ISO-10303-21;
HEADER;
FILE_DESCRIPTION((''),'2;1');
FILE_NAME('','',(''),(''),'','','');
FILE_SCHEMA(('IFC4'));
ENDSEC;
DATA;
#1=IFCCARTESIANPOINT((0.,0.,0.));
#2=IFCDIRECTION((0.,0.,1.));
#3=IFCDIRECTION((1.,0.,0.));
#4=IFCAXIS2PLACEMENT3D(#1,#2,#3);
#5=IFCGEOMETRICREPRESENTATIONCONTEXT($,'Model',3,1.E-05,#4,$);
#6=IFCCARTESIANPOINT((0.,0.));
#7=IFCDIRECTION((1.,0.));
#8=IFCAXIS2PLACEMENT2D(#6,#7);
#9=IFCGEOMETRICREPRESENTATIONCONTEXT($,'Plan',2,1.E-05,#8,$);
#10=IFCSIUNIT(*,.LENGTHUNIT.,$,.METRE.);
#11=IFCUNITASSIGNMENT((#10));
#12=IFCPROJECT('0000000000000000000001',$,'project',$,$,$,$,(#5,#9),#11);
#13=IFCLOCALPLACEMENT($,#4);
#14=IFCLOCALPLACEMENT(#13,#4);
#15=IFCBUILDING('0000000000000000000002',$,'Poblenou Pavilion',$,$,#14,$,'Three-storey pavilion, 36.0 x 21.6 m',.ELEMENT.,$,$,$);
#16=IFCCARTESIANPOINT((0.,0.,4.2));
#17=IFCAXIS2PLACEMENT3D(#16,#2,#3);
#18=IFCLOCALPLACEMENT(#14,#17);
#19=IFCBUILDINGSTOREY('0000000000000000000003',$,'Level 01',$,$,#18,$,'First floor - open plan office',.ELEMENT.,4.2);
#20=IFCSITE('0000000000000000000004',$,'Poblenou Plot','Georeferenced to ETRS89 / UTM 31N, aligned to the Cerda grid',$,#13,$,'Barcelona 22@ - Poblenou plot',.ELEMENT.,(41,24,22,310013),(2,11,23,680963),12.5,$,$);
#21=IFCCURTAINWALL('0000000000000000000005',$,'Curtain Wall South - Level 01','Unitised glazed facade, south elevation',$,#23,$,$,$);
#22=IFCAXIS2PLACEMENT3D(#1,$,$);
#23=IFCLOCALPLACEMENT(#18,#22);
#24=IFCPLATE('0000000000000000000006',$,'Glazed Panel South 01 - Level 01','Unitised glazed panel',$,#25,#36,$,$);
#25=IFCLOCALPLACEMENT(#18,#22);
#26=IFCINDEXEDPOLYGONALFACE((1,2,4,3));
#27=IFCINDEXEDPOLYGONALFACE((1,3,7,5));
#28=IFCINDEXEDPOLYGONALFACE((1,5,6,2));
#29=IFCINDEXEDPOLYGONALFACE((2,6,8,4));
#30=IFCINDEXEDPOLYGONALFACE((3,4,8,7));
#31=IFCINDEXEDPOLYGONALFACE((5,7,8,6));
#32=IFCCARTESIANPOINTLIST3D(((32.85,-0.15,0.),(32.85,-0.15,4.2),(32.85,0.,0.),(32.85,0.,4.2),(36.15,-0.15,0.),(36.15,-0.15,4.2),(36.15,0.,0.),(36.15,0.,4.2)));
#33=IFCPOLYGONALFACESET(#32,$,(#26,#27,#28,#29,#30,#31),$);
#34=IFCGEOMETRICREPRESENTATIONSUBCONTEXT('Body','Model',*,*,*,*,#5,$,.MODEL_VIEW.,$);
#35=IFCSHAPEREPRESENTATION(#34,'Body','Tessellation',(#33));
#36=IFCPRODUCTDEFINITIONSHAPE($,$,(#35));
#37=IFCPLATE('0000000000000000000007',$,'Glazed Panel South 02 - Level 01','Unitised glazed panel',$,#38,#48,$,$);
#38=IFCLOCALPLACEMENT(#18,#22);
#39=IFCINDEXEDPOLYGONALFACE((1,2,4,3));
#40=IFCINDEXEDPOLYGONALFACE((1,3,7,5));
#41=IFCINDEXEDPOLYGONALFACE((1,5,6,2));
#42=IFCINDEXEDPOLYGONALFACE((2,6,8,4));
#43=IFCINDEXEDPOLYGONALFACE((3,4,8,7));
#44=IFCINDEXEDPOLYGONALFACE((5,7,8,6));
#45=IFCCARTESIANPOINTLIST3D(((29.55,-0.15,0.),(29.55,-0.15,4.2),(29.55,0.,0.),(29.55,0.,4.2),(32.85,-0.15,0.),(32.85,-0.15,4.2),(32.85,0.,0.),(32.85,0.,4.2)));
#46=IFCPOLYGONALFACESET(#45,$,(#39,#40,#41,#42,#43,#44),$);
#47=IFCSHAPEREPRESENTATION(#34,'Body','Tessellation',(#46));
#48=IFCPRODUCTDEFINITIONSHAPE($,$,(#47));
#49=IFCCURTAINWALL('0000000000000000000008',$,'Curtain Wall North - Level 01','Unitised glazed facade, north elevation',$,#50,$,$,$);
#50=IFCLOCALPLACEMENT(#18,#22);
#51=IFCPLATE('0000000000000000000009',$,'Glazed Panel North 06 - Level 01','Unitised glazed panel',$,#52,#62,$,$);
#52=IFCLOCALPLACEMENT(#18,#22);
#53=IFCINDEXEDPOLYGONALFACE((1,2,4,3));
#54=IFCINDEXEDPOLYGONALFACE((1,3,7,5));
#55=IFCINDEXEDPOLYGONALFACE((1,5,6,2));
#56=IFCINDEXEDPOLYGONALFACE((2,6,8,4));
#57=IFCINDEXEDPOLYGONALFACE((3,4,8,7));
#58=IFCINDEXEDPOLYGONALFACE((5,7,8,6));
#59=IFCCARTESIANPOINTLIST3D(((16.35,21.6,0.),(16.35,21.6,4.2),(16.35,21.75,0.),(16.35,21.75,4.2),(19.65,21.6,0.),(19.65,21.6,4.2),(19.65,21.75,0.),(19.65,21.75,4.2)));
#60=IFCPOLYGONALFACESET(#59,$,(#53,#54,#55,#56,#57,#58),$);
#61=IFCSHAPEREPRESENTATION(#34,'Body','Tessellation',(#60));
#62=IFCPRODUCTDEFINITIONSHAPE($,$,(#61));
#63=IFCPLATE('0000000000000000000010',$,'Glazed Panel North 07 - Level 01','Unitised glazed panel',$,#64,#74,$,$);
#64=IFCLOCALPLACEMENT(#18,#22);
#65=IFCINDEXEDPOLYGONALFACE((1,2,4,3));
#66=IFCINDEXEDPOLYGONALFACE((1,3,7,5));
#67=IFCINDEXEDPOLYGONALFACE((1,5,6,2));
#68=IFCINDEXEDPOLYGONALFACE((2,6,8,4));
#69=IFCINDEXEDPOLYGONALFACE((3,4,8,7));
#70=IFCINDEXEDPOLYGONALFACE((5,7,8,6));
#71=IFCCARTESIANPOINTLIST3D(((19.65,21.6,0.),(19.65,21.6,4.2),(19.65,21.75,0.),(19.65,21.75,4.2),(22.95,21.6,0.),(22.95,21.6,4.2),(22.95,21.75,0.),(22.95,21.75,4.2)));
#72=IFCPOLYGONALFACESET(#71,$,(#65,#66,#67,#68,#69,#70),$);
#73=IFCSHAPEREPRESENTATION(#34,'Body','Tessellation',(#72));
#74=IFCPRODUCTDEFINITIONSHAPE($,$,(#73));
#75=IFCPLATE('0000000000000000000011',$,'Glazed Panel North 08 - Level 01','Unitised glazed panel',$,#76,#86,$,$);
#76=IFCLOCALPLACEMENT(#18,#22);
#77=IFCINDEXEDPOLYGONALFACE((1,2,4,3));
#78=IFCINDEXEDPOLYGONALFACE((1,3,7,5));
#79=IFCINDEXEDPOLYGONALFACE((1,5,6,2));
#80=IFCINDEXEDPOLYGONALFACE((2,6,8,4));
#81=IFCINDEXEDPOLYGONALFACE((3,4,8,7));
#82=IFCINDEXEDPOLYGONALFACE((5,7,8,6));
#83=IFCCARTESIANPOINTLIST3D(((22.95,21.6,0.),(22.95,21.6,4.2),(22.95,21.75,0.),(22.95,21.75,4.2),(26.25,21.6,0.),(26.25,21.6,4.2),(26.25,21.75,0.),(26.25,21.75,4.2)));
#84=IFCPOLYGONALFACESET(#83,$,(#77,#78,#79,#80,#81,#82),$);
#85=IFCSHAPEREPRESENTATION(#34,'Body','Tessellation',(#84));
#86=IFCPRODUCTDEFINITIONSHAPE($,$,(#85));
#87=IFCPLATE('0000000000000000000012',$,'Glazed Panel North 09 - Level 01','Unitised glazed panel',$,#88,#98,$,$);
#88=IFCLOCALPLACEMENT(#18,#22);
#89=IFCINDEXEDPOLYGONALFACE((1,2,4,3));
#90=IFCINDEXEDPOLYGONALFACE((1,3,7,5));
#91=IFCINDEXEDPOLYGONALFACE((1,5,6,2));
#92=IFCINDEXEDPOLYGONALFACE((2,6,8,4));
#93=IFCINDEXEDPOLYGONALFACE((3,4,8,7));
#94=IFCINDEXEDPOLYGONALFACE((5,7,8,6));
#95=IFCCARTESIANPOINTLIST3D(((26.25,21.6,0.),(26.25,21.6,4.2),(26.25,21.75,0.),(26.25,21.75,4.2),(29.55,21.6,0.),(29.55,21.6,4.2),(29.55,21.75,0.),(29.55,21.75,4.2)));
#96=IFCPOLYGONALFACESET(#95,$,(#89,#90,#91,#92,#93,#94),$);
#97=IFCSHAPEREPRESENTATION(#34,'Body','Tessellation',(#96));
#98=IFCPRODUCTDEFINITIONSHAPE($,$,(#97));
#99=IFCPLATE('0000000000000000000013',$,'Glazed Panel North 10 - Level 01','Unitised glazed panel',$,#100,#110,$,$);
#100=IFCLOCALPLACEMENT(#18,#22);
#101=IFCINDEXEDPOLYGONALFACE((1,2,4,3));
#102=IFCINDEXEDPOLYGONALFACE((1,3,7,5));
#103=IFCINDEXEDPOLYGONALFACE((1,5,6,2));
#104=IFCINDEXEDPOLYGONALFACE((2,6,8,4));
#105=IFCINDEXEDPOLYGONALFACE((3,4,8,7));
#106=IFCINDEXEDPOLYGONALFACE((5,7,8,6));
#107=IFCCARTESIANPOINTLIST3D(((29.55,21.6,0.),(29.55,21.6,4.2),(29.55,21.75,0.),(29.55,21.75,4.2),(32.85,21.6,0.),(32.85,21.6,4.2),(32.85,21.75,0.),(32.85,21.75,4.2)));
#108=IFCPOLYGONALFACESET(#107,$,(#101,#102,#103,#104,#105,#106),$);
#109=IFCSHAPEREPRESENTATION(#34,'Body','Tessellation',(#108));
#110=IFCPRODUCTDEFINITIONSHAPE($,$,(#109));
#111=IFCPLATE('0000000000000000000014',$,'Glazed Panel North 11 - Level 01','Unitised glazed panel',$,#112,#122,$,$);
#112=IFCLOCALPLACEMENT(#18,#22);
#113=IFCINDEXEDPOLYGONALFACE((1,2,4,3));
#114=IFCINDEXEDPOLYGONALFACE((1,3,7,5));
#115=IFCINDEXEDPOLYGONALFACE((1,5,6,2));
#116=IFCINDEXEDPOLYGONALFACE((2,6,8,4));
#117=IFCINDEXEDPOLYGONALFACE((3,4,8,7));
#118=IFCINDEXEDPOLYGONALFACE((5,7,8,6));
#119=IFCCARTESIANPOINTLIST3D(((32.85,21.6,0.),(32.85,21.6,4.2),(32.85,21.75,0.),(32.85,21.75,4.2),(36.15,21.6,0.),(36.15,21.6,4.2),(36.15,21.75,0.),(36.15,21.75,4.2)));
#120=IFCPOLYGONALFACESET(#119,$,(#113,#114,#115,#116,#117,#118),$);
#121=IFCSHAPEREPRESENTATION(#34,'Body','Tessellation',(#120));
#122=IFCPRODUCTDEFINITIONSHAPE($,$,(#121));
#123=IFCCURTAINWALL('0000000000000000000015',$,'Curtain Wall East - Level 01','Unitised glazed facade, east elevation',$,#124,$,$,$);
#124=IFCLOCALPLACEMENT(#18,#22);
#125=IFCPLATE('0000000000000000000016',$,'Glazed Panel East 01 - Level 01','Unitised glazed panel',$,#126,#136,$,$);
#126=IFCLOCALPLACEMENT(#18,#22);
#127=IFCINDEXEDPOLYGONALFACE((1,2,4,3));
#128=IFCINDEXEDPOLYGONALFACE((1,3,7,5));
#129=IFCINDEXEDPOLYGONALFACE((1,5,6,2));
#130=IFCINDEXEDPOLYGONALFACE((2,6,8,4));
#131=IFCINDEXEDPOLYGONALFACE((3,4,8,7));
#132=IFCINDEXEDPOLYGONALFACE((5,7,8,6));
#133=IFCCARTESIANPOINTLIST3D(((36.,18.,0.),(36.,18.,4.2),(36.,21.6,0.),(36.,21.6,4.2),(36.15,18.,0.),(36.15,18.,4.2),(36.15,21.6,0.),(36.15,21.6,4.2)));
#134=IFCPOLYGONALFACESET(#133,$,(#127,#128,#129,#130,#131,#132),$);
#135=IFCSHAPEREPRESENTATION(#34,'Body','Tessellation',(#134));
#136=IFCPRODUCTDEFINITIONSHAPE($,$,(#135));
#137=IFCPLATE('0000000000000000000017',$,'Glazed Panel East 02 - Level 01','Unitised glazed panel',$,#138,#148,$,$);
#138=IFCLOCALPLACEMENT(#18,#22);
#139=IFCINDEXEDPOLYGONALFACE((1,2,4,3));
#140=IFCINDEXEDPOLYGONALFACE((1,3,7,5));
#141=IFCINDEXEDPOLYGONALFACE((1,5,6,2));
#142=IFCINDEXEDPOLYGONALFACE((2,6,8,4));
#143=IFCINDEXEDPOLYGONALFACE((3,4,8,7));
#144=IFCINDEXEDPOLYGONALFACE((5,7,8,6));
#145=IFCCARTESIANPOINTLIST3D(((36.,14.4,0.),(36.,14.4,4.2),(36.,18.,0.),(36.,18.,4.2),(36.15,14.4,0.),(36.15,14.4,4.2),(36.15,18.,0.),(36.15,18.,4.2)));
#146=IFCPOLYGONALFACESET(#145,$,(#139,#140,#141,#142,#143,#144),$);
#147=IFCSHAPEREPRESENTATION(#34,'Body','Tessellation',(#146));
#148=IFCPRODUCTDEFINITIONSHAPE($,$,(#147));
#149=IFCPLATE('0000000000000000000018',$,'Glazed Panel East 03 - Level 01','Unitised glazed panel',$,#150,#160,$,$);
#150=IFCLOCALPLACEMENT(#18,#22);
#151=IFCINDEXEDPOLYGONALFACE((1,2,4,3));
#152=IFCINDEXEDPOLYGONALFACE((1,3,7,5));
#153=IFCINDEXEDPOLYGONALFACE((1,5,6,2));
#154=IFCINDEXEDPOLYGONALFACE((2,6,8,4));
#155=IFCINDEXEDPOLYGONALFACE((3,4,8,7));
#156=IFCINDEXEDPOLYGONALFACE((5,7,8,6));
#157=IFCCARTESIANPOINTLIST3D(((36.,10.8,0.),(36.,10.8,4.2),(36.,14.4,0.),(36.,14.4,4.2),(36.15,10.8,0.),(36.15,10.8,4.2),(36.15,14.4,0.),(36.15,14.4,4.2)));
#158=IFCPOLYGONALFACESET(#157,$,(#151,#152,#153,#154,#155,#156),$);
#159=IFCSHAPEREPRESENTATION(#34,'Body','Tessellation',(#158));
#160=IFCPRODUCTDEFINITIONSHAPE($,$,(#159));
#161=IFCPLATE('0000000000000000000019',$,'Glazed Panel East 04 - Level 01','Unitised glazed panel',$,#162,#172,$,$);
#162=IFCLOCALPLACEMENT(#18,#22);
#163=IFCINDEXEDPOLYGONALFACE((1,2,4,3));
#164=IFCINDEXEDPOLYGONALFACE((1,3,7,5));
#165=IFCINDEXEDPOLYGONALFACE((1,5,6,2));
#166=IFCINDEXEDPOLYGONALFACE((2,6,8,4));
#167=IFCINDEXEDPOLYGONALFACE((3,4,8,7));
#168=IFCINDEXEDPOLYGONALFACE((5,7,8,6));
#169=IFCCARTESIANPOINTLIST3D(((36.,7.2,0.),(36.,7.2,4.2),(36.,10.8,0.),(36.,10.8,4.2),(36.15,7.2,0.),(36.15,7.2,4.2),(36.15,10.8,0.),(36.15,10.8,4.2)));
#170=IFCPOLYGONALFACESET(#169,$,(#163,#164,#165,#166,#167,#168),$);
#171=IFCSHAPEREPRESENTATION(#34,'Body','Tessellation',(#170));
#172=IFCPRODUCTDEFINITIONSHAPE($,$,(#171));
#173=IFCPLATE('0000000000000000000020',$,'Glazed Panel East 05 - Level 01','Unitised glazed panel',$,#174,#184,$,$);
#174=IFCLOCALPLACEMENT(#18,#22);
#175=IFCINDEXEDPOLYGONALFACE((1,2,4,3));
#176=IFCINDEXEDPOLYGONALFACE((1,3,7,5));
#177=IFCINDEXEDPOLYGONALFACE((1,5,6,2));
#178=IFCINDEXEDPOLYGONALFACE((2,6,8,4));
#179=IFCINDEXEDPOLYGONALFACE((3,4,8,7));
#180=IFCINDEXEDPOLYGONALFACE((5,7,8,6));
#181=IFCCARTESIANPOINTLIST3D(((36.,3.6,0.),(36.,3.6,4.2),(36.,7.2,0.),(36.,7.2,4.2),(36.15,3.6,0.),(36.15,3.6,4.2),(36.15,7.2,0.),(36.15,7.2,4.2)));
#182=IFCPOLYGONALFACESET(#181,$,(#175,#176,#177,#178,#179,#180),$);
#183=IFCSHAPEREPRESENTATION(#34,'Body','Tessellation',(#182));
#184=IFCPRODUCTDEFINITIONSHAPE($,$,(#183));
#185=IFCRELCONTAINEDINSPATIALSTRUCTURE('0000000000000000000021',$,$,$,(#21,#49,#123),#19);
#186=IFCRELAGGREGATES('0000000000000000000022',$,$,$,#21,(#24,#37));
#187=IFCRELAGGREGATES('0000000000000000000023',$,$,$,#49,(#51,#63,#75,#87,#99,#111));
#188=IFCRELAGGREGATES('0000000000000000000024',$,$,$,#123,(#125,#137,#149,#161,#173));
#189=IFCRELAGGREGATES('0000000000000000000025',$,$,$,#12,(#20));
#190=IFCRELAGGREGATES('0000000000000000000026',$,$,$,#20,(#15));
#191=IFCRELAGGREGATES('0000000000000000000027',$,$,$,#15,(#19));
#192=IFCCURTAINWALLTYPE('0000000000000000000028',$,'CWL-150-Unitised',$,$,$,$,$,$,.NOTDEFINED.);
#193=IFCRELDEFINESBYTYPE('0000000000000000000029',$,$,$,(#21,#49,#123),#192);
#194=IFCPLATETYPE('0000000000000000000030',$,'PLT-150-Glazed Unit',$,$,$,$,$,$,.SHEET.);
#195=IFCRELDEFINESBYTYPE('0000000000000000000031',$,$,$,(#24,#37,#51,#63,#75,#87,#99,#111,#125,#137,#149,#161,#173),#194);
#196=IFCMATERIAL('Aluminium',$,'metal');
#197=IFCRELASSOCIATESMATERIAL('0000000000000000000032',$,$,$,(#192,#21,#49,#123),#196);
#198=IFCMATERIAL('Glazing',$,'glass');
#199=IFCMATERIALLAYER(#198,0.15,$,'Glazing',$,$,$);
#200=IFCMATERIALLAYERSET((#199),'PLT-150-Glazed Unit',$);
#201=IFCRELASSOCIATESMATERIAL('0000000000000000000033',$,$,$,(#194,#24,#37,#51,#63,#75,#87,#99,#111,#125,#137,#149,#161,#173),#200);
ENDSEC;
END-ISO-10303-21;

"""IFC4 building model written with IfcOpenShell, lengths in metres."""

from ifc_helpers import new_model, si_unit, frame, origin_with_axes, origin_2d_with_axis, place, context, subcontext, project, spatial, line, indexed_curve, outline, extrude, material, layer, layer_set, layer_usage, type_object, element, aggregate, save


model = new_model("IFC4")

# Units and contexts
model_context = context("Model", 3, precision=1e-05, world=origin_with_axes())
plan_context = context("Plan", 2, precision=1e-05, world=origin_2d_with_axis())
body_context = subcontext(model_context, "Body", "Model", "MODEL_VIEW")
ifc_project = project(units=[si_unit("LENGTHUNIT", "METRE")], contexts=[model_context, plan_context])

# Site, building, storey
site_placement = place(None, origin_with_axes())
site = spatial("IfcSite", under=ifc_project, at=site_placement, Name="Poblenou Plot", Description="Georeferenced to ETRS89 / UTM 31N, aligned to the Cerda grid", LongName="Barcelona 22@ - Poblenou plot", CompositionType="ELEMENT", RefLatitude=(41, 24, 22, 310013), RefLongitude=(2, 11, 23, 680963), RefElevation=12.5)
building_placement = place(site_placement, origin_with_axes())
building = spatial("IfcBuilding", under=site, at=building_placement, Name="Poblenou Pavilion", LongName="Three-storey pavilion, 36.0 x 21.6 m", CompositionType="ELEMENT")
storey_placement = place(building_placement, frame((0.0, 0.0, 4.2), z_axis=(0.0, 0.0, 1.0), x_axis=(1.0, 0.0, 0.0)))
storey = spatial("IfcBuildingStorey", under=building, at=storey_placement, Name="Level 01", LongName="First floor - open plan office", CompositionType="ELEMENT", Elevation=4.2)

# Curtain walls, plates
ifc_material_1 = material(Name="Aluminium", Category="metal")
curtain_wall_type = type_object("IfcCurtainWallType", Name="CWL-150-Unitised", PredefinedType="NOTDEFINED", material=ifc_material_1)
curtain_wall_1_placement = place(storey_placement, frame((36.15, 0.0, 0.0), z_axis=(0.0, 0.0, 1.0), x_axis=(-1.0, 0.0, 0.0)))
curtain_wall_1 = element("IfcCurtainWall", 1, at=curtain_wall_1_placement, inside=storey, type_object=curtain_wall_type, material=ifc_material_1, Name="Curtain Wall South - Level 01", Description="Unitised glazed facade, south elevation")
ifc_material_2 = material(Name="Glazing", Category="glass")
ifc_layer_1 = layer(ifc_material_2, 0.15, Name="Glazing")
ifc_layer_set_1 = layer_set([ifc_layer_1], Name="PLT-150-Glazed Unit")
ifc_layer_usage_1 = layer_usage(ifc_layer_set_1, "AXIS2", "POSITIVE", 0.0)
plate_type = type_object("IfcPlateType", Name="PLT-150-Glazed Unit", PredefinedType="SHEET", material=ifc_layer_set_1)
plate_1_placement = place(curtain_wall_1_placement, origin_with_axes())
plate_1 = element("IfcPlate", 2, at=plate_1_placement, type_object=plate_type, material=ifc_layer_usage_1, Name="Glazed Panel South 01 - Level 01", Description="Unitised glazed panel", context=body_context, shape_type="SweptSolid", body=[
    extrude(outline(indexed_curve([(0.0, 0.0), (3.3, 0.0), (3.3, 0.15), (0.0, 0.15)], segments=[line(1, 2, 3, 4, 1)])), origin_with_axes(), (0.0, 0.0, 1.0), 4.2),
])
ifc_layer_usage_2 = layer_usage(ifc_layer_set_1, "AXIS2", "POSITIVE", 0.0)
plate_2_placement = place(curtain_wall_1_placement, frame((3.3, 0.0, 0.0), z_axis=(0.0, 0.0, 1.0), x_axis=(1.0, 0.0, 0.0)))
plate_2 = element("IfcPlate", 3, at=plate_2_placement, type_object=plate_type, material=ifc_layer_usage_2, Name="Glazed Panel South 02 - Level 01", Description="Unitised glazed panel", context=body_context, shape_type="SweptSolid", body=[
    extrude(outline(indexed_curve([(0.0, 0.0), (3.3, 0.0), (3.3, 0.15), (0.0, 0.15)], segments=[line(1, 2, 3, 4, 1)])), origin_with_axes(), (0.0, 0.0, 1.0), 4.2),
])
aggregate(curtain_wall_1, [plate_1, plate_2])
curtain_wall_2_placement = place(storey_placement, frame((-0.15, 21.6, 0.0), z_axis=(0.0, 0.0, 1.0), x_axis=(1.0, 0.0, 0.0)))
curtain_wall_2 = element("IfcCurtainWall", 4, at=curtain_wall_2_placement, inside=storey, type_object=curtain_wall_type, material=ifc_material_1, Name="Curtain Wall North - Level 01", Description="Unitised glazed facade, north elevation")
ifc_layer_usage_3 = layer_usage(ifc_layer_set_1, "AXIS2", "POSITIVE", 0.0)
plate_3_placement = place(curtain_wall_2_placement, frame((16.5, 0.0, 0.0), z_axis=(0.0, 0.0, 1.0), x_axis=(1.0, 0.0, 0.0)))
plate_3 = element("IfcPlate", 5, at=plate_3_placement, type_object=plate_type, material=ifc_layer_usage_3, Name="Glazed Panel North 06 - Level 01", Description="Unitised glazed panel", context=body_context, shape_type="SweptSolid", body=[
    extrude(outline(indexed_curve([(0.0, 0.0), (3.3, 0.0), (3.3, 0.15), (0.0, 0.15)], segments=[line(1, 2, 3, 4, 1)])), origin_with_axes(), (0.0, 0.0, 1.0), 4.2),
])
ifc_layer_usage_4 = layer_usage(ifc_layer_set_1, "AXIS2", "POSITIVE", 0.0)
plate_4_placement = place(curtain_wall_2_placement, frame((19.8, 0.0, 0.0), z_axis=(0.0, 0.0, 1.0), x_axis=(1.0, 0.0, 0.0)))
plate_4 = element("IfcPlate", 6, at=plate_4_placement, type_object=plate_type, material=ifc_layer_usage_4, Name="Glazed Panel North 07 - Level 01", Description="Unitised glazed panel", context=body_context, shape_type="SweptSolid", body=[
    extrude(outline(indexed_curve([(0.0, 0.0), (3.3, 0.0), (3.3, 0.15), (0.0, 0.15)], segments=[line(1, 2, 3, 4, 1)])), origin_with_axes(), (0.0, 0.0, 1.0), 4.2),
])
ifc_layer_usage_5 = layer_usage(ifc_layer_set_1, "AXIS2", "POSITIVE", 0.0)
plate_5_placement = place(curtain_wall_2_placement, frame((23.1, 0.0, 0.0), z_axis=(0.0, 0.0, 1.0), x_axis=(1.0, 0.0, 0.0)))
plate_5 = element("IfcPlate", 7, at=plate_5_placement, type_object=plate_type, material=ifc_layer_usage_5, Name="Glazed Panel North 08 - Level 01", Description="Unitised glazed panel", context=body_context, shape_type="SweptSolid", body=[
    extrude(outline(indexed_curve([(0.0, 0.0), (3.3, 0.0), (3.3, 0.15), (0.0, 0.15)], segments=[line(1, 2, 3, 4, 1)])), origin_with_axes(), (0.0, 0.0, 1.0), 4.2),
])
ifc_layer_usage_6 = layer_usage(ifc_layer_set_1, "AXIS2", "POSITIVE", 0.0)
plate_6_placement = place(curtain_wall_2_placement, frame((26.4, 0.0, 0.0), z_axis=(0.0, 0.0, 1.0), x_axis=(1.0, 0.0, 0.0)))
plate_6 = element("IfcPlate", 8, at=plate_6_placement, type_object=plate_type, material=ifc_layer_usage_6, Name="Glazed Panel North 09 - Level 01", Description="Unitised glazed panel", context=body_context, shape_type="SweptSolid", body=[
    extrude(outline(indexed_curve([(0.0, 0.0), (3.3, 0.0), (3.3, 0.15), (0.0, 0.15)], segments=[line(1, 2, 3, 4, 1)])), origin_with_axes(), (0.0, 0.0, 1.0), 4.2),
])
ifc_layer_usage_7 = layer_usage(ifc_layer_set_1, "AXIS2", "POSITIVE", 0.0)
plate_7_placement = place(curtain_wall_2_placement, frame((29.7, 0.0, 0.0), z_axis=(0.0, 0.0, 1.0), x_axis=(1.0, 0.0, 0.0)))
plate_7 = element("IfcPlate", 9, at=plate_7_placement, type_object=plate_type, material=ifc_layer_usage_7, Name="Glazed Panel North 10 - Level 01", Description="Unitised glazed panel", context=body_context, shape_type="SweptSolid", body=[
    extrude(outline(indexed_curve([(0.0, 0.0), (3.3, 0.0), (3.3, 0.15), (0.0, 0.15)], segments=[line(1, 2, 3, 4, 1)])), origin_with_axes(), (0.0, 0.0, 1.0), 4.2),
])
ifc_layer_usage_8 = layer_usage(ifc_layer_set_1, "AXIS2", "POSITIVE", 0.0)
plate_8_placement = place(curtain_wall_2_placement, frame((33.0, 0.0, 0.0), z_axis=(0.0, 0.0, 1.0), x_axis=(1.0, 0.0, 0.0)))
plate_8 = element("IfcPlate", 10, at=plate_8_placement, type_object=plate_type, material=ifc_layer_usage_8, Name="Glazed Panel North 11 - Level 01", Description="Unitised glazed panel", context=body_context, shape_type="SweptSolid", body=[
    extrude(outline(indexed_curve([(0.0, 0.0), (3.3, 0.0), (3.3, 0.15), (0.0, 0.15)], segments=[line(1, 2, 3, 4, 1)])), origin_with_axes(), (0.0, 0.0, 1.0), 4.2),
])
aggregate(curtain_wall_2, [plate_3, plate_4, plate_5, plate_6, plate_7, plate_8])
curtain_wall_3_placement = place(storey_placement, frame((36.0, 21.6, 0.0), z_axis=(0.0, 0.0, 1.0), x_axis=(0.0, -1.0, 0.0)))
curtain_wall_3 = element("IfcCurtainWall", 11, at=curtain_wall_3_placement, inside=storey, type_object=curtain_wall_type, material=ifc_material_1, Name="Curtain Wall East - Level 01", Description="Unitised glazed facade, east elevation")
ifc_layer_usage_9 = layer_usage(ifc_layer_set_1, "AXIS2", "POSITIVE", 0.0)
plate_9_placement = place(curtain_wall_3_placement, origin_with_axes())
plate_9 = element("IfcPlate", 12, at=plate_9_placement, type_object=plate_type, material=ifc_layer_usage_9, Name="Glazed Panel East 01 - Level 01", Description="Unitised glazed panel", context=body_context, shape_type="SweptSolid", body=[
    extrude(outline(indexed_curve([(0.0, 0.0), (3.6, 0.0), (3.6, 0.15), (0.0, 0.15)], segments=[line(1, 2, 3, 4, 1)])), origin_with_axes(), (0.0, 0.0, 1.0), 4.2),
])
ifc_layer_usage_10 = layer_usage(ifc_layer_set_1, "AXIS2", "POSITIVE", 0.0)
plate_10_placement = place(curtain_wall_3_placement, frame((3.6, 0.0, 0.0), z_axis=(0.0, 0.0, 1.0), x_axis=(1.0, 0.0, 0.0)))
plate_10 = element("IfcPlate", 13, at=plate_10_placement, type_object=plate_type, material=ifc_layer_usage_10, Name="Glazed Panel East 02 - Level 01", Description="Unitised glazed panel", context=body_context, shape_type="SweptSolid", body=[
    extrude(outline(indexed_curve([(0.0, 0.0), (3.6, 0.0), (3.6, 0.15), (0.0, 0.15)], segments=[line(1, 2, 3, 4, 1)])), origin_with_axes(), (0.0, 0.0, 1.0), 4.2),
])
ifc_layer_usage_11 = layer_usage(ifc_layer_set_1, "AXIS2", "POSITIVE", 0.0)
plate_11_placement = place(curtain_wall_3_placement, frame((7.2, 0.0, 0.0), z_axis=(0.0, 0.0, 1.0), x_axis=(1.0, 0.0, 0.0)))
plate_11 = element("IfcPlate", 14, at=plate_11_placement, type_object=plate_type, material=ifc_layer_usage_11, Name="Glazed Panel East 03 - Level 01", Description="Unitised glazed panel", context=body_context, shape_type="SweptSolid", body=[
    extrude(outline(indexed_curve([(0.0, 0.0), (3.6, 0.0), (3.6, 0.15), (0.0, 0.15)], segments=[line(1, 2, 3, 4, 1)])), origin_with_axes(), (0.0, 0.0, 1.0), 4.2),
])
ifc_layer_usage_12 = layer_usage(ifc_layer_set_1, "AXIS2", "POSITIVE", 0.0)
plate_12_placement = place(curtain_wall_3_placement, frame((10.8, 0.0, 0.0), z_axis=(0.0, 0.0, 1.0), x_axis=(1.0, 0.0, 0.0)))
plate_12 = element("IfcPlate", 15, at=plate_12_placement, type_object=plate_type, material=ifc_layer_usage_12, Name="Glazed Panel East 04 - Level 01", Description="Unitised glazed panel", context=body_context, shape_type="SweptSolid", body=[
    extrude(outline(indexed_curve([(0.0, 0.0), (3.6, 0.0), (3.6, 0.15), (0.0, 0.15)], segments=[line(1, 2, 3, 4, 1)])), origin_with_axes(), (0.0, 0.0, 1.0), 4.2),
])
ifc_layer_usage_13 = layer_usage(ifc_layer_set_1, "AXIS2", "POSITIVE", 0.0)
plate_13_placement = place(curtain_wall_3_placement, frame((14.4, 0.0, 0.0), z_axis=(0.0, 0.0, 1.0), x_axis=(1.0, 0.0, 0.0)))
plate_13 = element("IfcPlate", 16, at=plate_13_placement, type_object=plate_type, material=ifc_layer_usage_13, Name="Glazed Panel East 05 - Level 01", Description="Unitised glazed panel", context=body_context, shape_type="SweptSolid", body=[
    extrude(outline(indexed_curve([(0.0, 0.0), (3.6, 0.0), (3.6, 0.15), (0.0, 0.15)], segments=[line(1, 2, 3, 4, 1)])), origin_with_axes(), (0.0, 0.0, 1.0), 4.2),
])
aggregate(curtain_wall_3, [plate_9, plate_10, plate_11, plate_12, plate_13])

save(model, "model.ifc")
